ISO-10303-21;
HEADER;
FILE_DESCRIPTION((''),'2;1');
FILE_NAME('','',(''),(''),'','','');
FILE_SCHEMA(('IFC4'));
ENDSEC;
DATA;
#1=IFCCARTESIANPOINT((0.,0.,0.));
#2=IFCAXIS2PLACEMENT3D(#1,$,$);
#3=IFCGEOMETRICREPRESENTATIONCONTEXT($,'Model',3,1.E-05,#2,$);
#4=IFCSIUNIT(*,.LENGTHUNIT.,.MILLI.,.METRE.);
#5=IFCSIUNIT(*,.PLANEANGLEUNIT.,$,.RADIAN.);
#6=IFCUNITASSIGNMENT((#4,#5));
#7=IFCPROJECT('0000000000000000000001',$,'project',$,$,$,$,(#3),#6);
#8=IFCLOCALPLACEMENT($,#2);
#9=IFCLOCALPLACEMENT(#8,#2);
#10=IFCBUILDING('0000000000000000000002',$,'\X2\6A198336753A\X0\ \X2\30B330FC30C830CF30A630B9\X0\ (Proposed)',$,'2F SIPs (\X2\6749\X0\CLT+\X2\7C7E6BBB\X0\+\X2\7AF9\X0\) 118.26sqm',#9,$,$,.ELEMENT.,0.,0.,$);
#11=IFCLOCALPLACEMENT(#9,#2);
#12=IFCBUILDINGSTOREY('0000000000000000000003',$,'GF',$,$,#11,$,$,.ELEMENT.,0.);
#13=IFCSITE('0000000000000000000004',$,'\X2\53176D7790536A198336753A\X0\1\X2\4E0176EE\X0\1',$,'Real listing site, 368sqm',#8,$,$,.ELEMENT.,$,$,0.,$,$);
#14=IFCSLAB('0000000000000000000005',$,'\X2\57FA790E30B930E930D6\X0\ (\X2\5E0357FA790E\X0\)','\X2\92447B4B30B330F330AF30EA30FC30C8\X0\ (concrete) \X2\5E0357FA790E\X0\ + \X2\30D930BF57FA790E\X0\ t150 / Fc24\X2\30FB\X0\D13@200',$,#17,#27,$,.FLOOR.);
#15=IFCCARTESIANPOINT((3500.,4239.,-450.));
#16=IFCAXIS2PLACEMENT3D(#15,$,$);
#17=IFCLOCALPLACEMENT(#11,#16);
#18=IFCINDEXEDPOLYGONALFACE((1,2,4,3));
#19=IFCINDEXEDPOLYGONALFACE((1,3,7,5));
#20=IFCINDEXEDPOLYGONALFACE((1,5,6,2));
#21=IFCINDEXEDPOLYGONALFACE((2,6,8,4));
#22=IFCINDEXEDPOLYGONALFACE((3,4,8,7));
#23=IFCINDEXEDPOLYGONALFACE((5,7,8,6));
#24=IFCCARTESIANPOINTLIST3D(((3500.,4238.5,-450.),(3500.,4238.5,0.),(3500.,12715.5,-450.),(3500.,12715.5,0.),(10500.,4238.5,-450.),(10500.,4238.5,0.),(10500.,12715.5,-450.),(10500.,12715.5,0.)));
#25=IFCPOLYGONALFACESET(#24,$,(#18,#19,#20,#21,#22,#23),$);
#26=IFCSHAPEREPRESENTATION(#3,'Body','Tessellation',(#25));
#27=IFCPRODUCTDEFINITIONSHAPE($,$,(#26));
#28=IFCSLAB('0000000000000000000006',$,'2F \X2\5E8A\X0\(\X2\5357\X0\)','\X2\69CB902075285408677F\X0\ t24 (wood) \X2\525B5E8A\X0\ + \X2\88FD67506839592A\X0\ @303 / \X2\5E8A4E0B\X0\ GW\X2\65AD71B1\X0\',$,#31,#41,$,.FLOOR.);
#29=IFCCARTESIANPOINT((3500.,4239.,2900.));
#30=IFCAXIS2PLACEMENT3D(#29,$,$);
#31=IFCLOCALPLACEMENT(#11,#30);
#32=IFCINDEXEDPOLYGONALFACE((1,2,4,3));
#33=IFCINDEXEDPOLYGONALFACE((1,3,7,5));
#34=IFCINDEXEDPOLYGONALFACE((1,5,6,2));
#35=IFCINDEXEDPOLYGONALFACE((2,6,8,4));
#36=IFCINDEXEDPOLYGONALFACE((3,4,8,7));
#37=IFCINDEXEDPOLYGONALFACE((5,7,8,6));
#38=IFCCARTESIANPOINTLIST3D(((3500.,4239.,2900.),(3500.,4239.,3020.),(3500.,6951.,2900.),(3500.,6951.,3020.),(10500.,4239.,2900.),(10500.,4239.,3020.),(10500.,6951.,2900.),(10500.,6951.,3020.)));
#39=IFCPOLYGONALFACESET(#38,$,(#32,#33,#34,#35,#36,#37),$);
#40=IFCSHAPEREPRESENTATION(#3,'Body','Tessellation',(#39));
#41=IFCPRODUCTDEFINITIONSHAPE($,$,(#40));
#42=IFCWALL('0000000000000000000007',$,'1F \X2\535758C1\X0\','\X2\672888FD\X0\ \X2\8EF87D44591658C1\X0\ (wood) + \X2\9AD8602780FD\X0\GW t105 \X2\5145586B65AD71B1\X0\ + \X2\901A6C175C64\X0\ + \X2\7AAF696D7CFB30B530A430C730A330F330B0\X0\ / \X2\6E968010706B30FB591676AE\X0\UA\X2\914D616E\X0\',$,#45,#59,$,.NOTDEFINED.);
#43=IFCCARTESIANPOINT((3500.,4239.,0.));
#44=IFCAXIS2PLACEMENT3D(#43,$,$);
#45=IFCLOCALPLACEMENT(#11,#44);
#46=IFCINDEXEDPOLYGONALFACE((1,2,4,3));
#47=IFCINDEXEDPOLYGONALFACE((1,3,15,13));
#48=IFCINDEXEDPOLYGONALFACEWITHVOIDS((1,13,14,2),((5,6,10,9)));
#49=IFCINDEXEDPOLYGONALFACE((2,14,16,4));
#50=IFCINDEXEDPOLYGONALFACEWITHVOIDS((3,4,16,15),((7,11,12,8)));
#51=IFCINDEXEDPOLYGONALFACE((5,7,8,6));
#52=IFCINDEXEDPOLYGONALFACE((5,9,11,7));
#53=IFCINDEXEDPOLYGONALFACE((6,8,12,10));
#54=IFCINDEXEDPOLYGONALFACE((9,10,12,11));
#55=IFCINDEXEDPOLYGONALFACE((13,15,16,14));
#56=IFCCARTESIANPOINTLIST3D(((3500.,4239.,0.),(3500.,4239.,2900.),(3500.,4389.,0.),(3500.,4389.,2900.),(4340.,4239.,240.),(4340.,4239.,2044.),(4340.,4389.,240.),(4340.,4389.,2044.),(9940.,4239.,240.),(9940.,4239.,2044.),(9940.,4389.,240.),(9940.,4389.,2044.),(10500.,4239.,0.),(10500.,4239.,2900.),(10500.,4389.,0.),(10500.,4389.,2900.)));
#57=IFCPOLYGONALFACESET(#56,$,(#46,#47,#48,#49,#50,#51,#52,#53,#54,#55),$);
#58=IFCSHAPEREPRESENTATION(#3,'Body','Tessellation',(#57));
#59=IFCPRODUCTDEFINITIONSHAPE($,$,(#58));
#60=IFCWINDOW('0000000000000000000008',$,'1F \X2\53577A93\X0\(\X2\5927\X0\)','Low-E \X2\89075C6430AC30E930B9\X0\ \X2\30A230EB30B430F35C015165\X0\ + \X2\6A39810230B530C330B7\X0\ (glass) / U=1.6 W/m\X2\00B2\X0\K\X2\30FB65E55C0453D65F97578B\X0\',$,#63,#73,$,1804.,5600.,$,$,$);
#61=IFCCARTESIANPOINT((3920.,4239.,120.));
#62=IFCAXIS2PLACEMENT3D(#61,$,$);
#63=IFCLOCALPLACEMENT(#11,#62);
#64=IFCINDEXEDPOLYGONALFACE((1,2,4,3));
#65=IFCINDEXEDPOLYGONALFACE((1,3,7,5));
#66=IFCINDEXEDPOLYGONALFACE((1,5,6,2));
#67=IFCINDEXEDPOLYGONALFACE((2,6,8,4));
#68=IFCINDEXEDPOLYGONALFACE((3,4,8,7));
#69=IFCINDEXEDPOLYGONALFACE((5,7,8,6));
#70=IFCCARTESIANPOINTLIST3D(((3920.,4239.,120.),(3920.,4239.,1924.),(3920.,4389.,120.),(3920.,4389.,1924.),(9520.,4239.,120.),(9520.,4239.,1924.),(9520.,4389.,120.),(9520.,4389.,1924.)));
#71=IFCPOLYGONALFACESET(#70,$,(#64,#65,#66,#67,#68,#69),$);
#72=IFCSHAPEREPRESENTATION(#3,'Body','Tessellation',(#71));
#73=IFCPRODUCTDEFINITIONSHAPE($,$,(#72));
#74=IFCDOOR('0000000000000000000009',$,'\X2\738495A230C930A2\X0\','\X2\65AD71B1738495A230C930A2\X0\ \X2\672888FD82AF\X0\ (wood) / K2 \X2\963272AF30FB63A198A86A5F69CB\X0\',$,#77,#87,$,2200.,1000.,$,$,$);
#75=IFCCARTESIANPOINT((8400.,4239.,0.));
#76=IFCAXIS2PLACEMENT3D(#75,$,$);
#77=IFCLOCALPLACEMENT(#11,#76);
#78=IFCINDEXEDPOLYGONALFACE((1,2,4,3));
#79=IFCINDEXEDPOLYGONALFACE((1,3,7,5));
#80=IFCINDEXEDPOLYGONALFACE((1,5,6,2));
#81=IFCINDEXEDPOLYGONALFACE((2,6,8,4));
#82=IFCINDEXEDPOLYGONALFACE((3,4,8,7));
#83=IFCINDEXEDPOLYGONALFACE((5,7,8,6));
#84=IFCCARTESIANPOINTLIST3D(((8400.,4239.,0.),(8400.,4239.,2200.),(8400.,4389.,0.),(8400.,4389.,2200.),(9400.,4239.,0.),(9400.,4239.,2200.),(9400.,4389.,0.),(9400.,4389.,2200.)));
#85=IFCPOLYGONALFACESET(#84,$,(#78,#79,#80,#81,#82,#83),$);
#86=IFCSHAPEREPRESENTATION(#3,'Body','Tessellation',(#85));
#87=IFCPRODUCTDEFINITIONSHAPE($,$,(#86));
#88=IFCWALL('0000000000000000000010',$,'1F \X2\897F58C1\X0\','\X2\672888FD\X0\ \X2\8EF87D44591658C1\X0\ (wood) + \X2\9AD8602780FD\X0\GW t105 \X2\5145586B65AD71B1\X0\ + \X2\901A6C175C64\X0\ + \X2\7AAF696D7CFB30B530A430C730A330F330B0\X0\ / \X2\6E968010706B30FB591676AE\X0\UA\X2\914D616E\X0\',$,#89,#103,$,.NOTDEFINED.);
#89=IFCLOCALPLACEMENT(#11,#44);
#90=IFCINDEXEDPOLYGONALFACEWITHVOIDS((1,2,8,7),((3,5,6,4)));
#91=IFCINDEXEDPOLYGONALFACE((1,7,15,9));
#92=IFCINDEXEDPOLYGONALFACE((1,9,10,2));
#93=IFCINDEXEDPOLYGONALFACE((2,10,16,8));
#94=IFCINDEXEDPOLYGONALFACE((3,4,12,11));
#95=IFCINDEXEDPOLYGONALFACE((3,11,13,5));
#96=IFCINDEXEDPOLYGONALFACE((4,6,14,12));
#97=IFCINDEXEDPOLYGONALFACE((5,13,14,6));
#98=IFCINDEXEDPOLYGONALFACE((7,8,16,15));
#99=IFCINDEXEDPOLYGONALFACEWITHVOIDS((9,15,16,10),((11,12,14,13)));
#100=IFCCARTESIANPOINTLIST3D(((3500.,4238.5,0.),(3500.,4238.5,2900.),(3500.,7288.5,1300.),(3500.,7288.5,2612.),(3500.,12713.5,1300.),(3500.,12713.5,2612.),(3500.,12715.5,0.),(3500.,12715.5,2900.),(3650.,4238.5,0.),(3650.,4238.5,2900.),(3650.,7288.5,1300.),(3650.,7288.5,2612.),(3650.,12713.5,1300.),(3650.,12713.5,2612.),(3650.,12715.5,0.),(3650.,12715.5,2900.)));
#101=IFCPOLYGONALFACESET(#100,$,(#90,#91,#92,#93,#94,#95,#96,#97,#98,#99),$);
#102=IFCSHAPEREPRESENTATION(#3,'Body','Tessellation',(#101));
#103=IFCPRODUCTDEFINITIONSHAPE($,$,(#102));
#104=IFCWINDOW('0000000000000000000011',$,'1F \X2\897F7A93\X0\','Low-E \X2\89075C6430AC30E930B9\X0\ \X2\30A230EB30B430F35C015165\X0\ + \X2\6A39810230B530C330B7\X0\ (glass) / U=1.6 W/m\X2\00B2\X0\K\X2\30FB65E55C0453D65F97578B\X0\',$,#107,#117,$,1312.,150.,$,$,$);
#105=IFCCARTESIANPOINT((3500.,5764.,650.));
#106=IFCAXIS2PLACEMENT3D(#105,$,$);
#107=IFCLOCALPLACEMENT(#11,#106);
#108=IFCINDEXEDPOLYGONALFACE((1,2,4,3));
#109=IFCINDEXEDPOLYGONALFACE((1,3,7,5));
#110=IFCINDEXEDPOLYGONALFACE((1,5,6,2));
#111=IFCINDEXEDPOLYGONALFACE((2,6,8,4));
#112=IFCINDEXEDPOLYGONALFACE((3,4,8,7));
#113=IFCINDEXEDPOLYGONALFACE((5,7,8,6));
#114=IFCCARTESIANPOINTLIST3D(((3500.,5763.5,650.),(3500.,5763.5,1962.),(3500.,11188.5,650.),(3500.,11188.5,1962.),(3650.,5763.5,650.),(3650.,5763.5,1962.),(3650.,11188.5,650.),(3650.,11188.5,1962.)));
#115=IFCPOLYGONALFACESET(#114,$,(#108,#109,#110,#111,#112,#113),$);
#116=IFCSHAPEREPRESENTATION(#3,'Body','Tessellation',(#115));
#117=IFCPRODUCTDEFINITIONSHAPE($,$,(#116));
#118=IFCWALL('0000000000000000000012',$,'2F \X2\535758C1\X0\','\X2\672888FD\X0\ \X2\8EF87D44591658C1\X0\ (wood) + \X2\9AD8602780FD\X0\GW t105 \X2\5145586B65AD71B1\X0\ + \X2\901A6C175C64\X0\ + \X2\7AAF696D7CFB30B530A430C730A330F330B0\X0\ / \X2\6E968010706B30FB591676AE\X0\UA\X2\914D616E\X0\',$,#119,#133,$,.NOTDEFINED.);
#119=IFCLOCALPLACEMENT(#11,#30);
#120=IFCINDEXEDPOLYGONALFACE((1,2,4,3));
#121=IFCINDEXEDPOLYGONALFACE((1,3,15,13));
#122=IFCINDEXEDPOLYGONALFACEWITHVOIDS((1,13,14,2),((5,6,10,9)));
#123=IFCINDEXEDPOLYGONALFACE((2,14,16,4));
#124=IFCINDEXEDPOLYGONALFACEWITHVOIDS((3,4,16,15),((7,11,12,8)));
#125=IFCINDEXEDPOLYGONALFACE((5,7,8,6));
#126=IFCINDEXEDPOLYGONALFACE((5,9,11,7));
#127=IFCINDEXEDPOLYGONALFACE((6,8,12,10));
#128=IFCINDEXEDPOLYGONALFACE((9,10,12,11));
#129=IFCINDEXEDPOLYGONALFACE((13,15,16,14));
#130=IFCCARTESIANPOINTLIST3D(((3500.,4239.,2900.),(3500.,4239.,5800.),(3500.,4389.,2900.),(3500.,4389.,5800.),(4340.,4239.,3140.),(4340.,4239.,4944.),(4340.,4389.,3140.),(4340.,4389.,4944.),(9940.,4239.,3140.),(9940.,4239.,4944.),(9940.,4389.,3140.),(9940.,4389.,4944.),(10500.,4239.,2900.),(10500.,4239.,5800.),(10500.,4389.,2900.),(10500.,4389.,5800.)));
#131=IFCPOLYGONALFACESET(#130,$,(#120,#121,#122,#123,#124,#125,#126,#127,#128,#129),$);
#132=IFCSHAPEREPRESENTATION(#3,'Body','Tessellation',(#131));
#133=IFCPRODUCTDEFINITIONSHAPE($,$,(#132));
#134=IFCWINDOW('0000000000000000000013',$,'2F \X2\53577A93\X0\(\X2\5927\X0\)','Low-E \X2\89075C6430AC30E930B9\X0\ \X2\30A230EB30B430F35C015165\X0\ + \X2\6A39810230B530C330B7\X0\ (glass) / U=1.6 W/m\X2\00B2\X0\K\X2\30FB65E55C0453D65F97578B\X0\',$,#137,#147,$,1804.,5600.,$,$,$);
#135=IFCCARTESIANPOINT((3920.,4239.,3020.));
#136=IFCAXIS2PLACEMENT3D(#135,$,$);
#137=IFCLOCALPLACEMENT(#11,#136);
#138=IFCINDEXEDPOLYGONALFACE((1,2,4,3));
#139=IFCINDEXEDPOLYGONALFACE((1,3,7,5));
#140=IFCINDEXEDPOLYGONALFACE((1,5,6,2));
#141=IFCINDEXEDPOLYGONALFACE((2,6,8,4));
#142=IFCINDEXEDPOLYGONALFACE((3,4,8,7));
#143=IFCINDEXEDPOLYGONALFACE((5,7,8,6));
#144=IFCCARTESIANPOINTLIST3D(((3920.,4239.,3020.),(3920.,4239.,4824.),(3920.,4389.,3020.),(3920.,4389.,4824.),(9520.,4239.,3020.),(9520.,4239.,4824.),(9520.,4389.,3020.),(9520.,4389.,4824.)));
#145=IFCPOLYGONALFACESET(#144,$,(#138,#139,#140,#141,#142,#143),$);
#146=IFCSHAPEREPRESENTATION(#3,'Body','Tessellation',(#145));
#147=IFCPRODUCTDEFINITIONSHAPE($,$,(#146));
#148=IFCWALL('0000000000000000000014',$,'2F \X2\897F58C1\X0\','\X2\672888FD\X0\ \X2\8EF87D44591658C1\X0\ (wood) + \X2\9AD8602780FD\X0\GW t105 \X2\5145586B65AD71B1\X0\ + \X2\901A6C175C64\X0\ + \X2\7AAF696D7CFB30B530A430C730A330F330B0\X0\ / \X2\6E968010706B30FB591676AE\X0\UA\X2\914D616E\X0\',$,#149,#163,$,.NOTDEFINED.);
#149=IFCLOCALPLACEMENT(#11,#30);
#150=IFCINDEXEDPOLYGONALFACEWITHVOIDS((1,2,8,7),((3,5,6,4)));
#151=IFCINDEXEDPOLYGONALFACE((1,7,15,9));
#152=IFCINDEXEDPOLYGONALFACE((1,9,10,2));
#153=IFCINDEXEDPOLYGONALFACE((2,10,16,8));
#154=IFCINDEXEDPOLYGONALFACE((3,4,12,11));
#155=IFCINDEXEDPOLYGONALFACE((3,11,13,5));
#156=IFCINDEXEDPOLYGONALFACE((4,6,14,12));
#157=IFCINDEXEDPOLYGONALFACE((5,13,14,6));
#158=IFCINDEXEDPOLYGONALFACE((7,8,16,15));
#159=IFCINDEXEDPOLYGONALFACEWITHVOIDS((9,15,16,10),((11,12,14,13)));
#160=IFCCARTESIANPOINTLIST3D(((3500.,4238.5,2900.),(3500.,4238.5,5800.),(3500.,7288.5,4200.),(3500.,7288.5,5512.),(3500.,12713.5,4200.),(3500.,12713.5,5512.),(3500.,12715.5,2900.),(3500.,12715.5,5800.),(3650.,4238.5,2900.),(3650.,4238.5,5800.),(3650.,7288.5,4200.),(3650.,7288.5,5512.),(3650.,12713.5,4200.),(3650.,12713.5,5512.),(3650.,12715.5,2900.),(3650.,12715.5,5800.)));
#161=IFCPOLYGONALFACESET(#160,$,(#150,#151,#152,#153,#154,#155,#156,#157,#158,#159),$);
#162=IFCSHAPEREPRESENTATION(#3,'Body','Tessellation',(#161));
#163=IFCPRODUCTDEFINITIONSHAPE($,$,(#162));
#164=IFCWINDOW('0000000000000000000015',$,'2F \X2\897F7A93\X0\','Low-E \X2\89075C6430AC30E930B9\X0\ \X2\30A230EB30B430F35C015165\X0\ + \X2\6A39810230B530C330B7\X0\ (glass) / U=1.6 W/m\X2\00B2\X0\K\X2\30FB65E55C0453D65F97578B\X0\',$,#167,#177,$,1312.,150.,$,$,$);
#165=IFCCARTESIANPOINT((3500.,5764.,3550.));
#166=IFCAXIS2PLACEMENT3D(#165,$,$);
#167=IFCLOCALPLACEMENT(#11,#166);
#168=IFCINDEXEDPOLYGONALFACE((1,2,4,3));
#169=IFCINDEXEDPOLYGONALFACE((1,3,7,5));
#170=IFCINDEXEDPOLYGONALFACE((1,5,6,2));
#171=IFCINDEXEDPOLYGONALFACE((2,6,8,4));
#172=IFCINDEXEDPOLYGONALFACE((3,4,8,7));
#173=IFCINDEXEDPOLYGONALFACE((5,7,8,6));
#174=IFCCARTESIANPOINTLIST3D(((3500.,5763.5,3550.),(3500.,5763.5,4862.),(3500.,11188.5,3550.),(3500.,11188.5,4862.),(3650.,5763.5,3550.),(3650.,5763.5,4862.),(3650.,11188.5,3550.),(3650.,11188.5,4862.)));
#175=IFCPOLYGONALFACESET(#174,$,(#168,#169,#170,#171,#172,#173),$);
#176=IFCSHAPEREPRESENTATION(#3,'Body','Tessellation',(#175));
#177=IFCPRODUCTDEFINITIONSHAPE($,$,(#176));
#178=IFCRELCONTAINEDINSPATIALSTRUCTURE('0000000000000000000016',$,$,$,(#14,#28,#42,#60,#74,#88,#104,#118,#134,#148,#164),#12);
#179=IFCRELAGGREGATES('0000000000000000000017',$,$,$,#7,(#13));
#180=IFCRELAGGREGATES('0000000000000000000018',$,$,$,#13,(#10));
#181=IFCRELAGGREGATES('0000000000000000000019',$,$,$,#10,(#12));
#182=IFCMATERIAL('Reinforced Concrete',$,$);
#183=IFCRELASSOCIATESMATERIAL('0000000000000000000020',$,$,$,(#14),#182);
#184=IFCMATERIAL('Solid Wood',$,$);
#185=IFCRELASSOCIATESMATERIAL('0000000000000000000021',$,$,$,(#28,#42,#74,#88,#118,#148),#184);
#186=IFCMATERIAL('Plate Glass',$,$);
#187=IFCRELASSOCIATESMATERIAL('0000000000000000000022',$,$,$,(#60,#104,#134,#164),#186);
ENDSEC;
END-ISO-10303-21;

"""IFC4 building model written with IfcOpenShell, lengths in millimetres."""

from ifc_helpers import new_model, si_unit, frame, frame_2d, origin, place, context, project, spatial, rectangle, extrude, material, element, fill, save


model = new_model("IFC4")

# Units and contexts
model_context = context("Model", 3, precision=1e-05, world=origin())
ifc_project = project(units=[si_unit("LENGTHUNIT", "METRE", prefix="MILLI"), si_unit("PLANEANGLEUNIT", "RADIAN")], contexts=[model_context])

# Site, building, storey
site_placement = place(None, origin())
site = spatial("IfcSite", under=ifc_project, at=site_placement, Name="北海道標茶町1丁目1", ObjectType="Real listing site, 368sqm", CompositionType="ELEMENT", RefElevation=0.0)
building_placement = place(site_placement, origin())
building = spatial("IfcBuilding", under=site, at=building_placement, Name="標茶町 コートハウス (Proposed)", ObjectType="2F SIPs (杉CLT+籾殻+竹) 118.26sqm", CompositionType="ELEMENT", ElevationOfRefHeight=0.0, ElevationOfTerrain=0.0)
storey_placement = place(building_placement, origin())
storey = spatial("IfcBuildingStorey", under=building, at=storey_placement, Name="GF", CompositionType="ELEMENT", Elevation=0.0)

# Slabs
ifc_material_1 = material(Name="Reinforced Concrete")
slab_1_placement = place(storey_placement, frame((3500.0, 4239.0, -450.0)))
element("IfcSlab", 1, at=slab_1_placement, inside=storey, material=ifc_material_1, Name="基礎スラブ (布基礎)", Description="鉄筋コンクリート (concrete) 布基礎 + ベタ基礎 t150 / Fc24・D13@200", PredefinedType="FLOOR", context=model_context, shape_type="SweptSolid", body=[
    extrude(rectangle(XDim=7000.0, YDim=8477.0, at=frame_2d((3500.0, 4238.0))), frame((3500.0, 4239.0, -450.0)), (0.0, 0.0, 1.0), 450.0),
])
ifc_material_2 = material(Name="Solid Wood")
slab_2_placement = place(storey_placement, frame((3500.0, 4239.0, 2900.0)))
element("IfcSlab", 2, at=slab_2_placement, inside=storey, material=ifc_material_2, Name="2F 床(南)", Description="構造用合板 t24 (wood) 剛床 + 製材根太 @303 / 床下 GW断熱", PredefinedType="FLOOR", context=model_context, shape_type="SweptSolid", body=[
    extrude(rectangle(XDim=7000.0, YDim=2712.0, at=frame_2d((3500.0, 1356.0))), frame((3500.0, 4239.0, 2900.0)), (0.0, 0.0, 1.0), 120.0),
])

# Wall, openings, window, door
wall_1_placement = place(storey_placement, frame((3500.0, 4239.0, 0.0)))
wall_1 = element("IfcWall", 3, at=wall_1_placement, inside=storey, material=ifc_material_2, Name="1F 南壁", Description="木製 軸組外壁 (wood) + 高性能GW t105 充填断熱 + 通気層 + 窯業系サイディング / 準耐火・外皮UA配慮", PredefinedType="NOTDEFINED", context=model_context, shape_type="SweptSolid", body=[
    extrude(rectangle(XDim=7000.0, YDim=150.0, at=frame_2d((3500.0, 75.0))), frame((3500.0, 4239.0, 0.0)), (0.0, 0.0, 1.0), 2900.0),
])
opening_1_placement = place(storey_placement, frame((3920.0, 4239.0, 120.0)))
opening_1 = element("IfcOpeningElement", 4, at=opening_1_placement, cuts=wall_1, PredefinedType="NOTDEFINED", context=model_context, shape_type="SweptSolid", body=[
    extrude(rectangle(XDim=5600.0, YDim=150.0, at=frame_2d((2800.0, 75.0))), frame((3920.0, 4239.0, 120.0)), (0.0, 0.0, 1.0), 1804.0),
])
opening_2_placement = place(storey_placement, frame((8400.0, 4239.0, 0.0)))
opening_2 = element("IfcOpeningElement", 5, at=opening_2_placement, cuts=wall_1, PredefinedType="NOTDEFINED", context=model_context, shape_type="SweptSolid", body=[
    extrude(rectangle(XDim=1000.0, YDim=150.0, at=frame_2d((500.0, 75.0))), frame((8400.0, 4239.0, 0.0)), (0.0, 0.0, 1.0), 2200.0),
])
ifc_material_3 = material(Name="Plate Glass")
window_1_placement = place(storey_placement, frame((3920.0, 4239.0, 120.0)))
window_1 = element("IfcWindow", 6, at=window_1_placement, inside=storey, material=ifc_material_3, Name="1F 南窓(大)", Description="Low-E 複層ガラス アルゴン封入 + 樹脂サッシ (glass) / U=1.6 W/m²K・日射取得型", OverallHeight=1804.0, OverallWidth=5600.0, context=model_context, shape_type="SweptSolid", body=[
    extrude(rectangle(XDim=5600.0, YDim=150.0, at=frame_2d((2800.0, 75.0))), frame((3920.0, 4239.0, 120.0)), (0.0, 0.0, 1.0), 1804.0),
])
fill(opening_1, window_1)
door_placement = place(storey_placement, frame((8400.0, 4239.0, 0.0)))
door = element("IfcDoor", 7, at=door_placement, inside=storey, material=ifc_material_2, Name="玄関ドア", Description="断熱玄関ドア 木製芯 (wood) / K2 防犯・採風機構", OverallHeight=2200.0, OverallWidth=1000.0, context=model_context, shape_type="SweptSolid", body=[
    extrude(rectangle(XDim=1000.0, YDim=150.0, at=frame_2d((500.0, 75.0))), frame((8400.0, 4239.0, 0.0)), (0.0, 0.0, 1.0), 2200.0),
])
fill(opening_2, door)

# Walls, openings, windows
wall_2_placement = place(storey_placement, frame((3500.0, 4239.0, 0.0)))
wall_2 = element("IfcWall", 8, at=wall_2_placement, inside=storey, material=ifc_material_2, Name="1F 西壁", Description="木製 軸組外壁 (wood) + 高性能GW t105 充填断熱 + 通気層 + 窯業系サイディング / 準耐火・外皮UA配慮", PredefinedType="NOTDEFINED", context=model_context, shape_type="SweptSolid", body=[
    extrude(rectangle(XDim=150.0, YDim=8477.0, at=frame_2d((75.0, 4238.0))), frame((3500.0, 4239.0, 0.0)), (0.0, 0.0, 1.0), 2900.0),
])
opening_3_placement = place(storey_placement, frame((3500.0, 5764.0, 650.0)))
opening_3 = element("IfcOpeningElement", 9, at=opening_3_placement, cuts=wall_2, PredefinedType="NOTDEFINED", context=model_context, shape_type="SweptSolid", body=[
    extrude(rectangle(XDim=150.0, YDim=5425.0, at=frame_2d((75.0, 2712.0))), frame((3500.0, 5764.0, 650.0)), (0.0, 0.0, 1.0), 1312.0),
])
window_2_placement = place(storey_placement, frame((3500.0, 5764.0, 650.0)))
window_2 = element("IfcWindow", 10, at=window_2_placement, inside=storey, material=ifc_material_3, Name="1F 西窓", Description="Low-E 複層ガラス アルゴン封入 + 樹脂サッシ (glass) / U=1.6 W/m²K・日射取得型", OverallHeight=1312.0, OverallWidth=150.0, context=model_context, shape_type="SweptSolid", body=[
    extrude(rectangle(XDim=150.0, YDim=5425.0, at=frame_2d((75.0, 2712.0))), frame((3500.0, 5764.0, 650.0)), (0.0, 0.0, 1.0), 1312.0),
])
fill(opening_3, window_2)
wall_3_placement = place(storey_placement, frame((3500.0, 4239.0, 2900.0)))
wall_3 = element("IfcWall", 11, at=wall_3_placement, inside=storey, material=ifc_material_2, Name="2F 南壁", Description="木製 軸組外壁 (wood) + 高性能GW t105 充填断熱 + 通気層 + 窯業系サイディング / 準耐火・外皮UA配慮", PredefinedType="NOTDEFINED", context=model_context, shape_type="SweptSolid", body=[
    extrude(rectangle(XDim=7000.0, YDim=150.0, at=frame_2d((3500.0, 75.0))), frame((3500.0, 4239.0, 2900.0)), (0.0, 0.0, 1.0), 2900.0),
])
opening_4_placement = place(storey_placement, frame((3920.0, 4239.0, 3020.0)))
opening_4 = element("IfcOpeningElement", 12, at=opening_4_placement, cuts=wall_3, PredefinedType="NOTDEFINED", context=model_context, shape_type="SweptSolid", body=[
    extrude(rectangle(XDim=5600.0, YDim=150.0, at=frame_2d((2800.0, 75.0))), frame((3920.0, 4239.0, 3020.0)), (0.0, 0.0, 1.0), 1804.0),
])
window_3_placement = place(storey_placement, frame((3920.0, 4239.0, 3020.0)))
window_3 = element("IfcWindow", 13, at=window_3_placement, inside=storey, material=ifc_material_3, Name="2F 南窓(大)", Description="Low-E 複層ガラス アルゴン封入 + 樹脂サッシ (glass) / U=1.6 W/m²K・日射取得型", OverallHeight=1804.0, OverallWidth=5600.0, context=model_context, shape_type="SweptSolid", body=[
    extrude(rectangle(XDim=5600.0, YDim=150.0, at=frame_2d((2800.0, 75.0))), frame((3920.0, 4239.0, 3020.0)), (0.0, 0.0, 1.0), 1804.0),
])
fill(opening_4, window_3)
wall_4_placement = place(storey_placement, frame((3500.0, 4239.0, 2900.0)))
wall_4 = element("IfcWall", 14, at=wall_4_placement, inside=storey, material=ifc_material_2, Name="2F 西壁", Description="木製 軸組外壁 (wood) + 高性能GW t105 充填断熱 + 通気層 + 窯業系サイディング / 準耐火・外皮UA配慮", PredefinedType="NOTDEFINED", context=model_context, shape_type="SweptSolid", body=[
    extrude(rectangle(XDim=150.0, YDim=8477.0, at=frame_2d((75.0, 4238.0))), frame((3500.0, 4239.0, 2900.0)), (0.0, 0.0, 1.0), 2900.0),
])
opening_5_placement = place(storey_placement, frame((3500.0, 5764.0, 3550.0)))
opening_5 = element("IfcOpeningElement", 15, at=opening_5_placement, cuts=wall_4, PredefinedType="NOTDEFINED", context=model_context, shape_type="SweptSolid", body=[
    extrude(rectangle(XDim=150.0, YDim=5425.0, at=frame_2d((75.0, 2712.0))), frame((3500.0, 5764.0, 3550.0)), (0.0, 0.0, 1.0), 1312.0),
])
window_4_placement = place(storey_placement, frame((3500.0, 5764.0, 3550.0)))
window_4 = element("IfcWindow", 16, at=window_4_placement, inside=storey, material=ifc_material_3, Name="2F 西窓", Description="Low-E 複層ガラス アルゴン封入 + 樹脂サッシ (glass) / U=1.6 W/m²K・日射取得型", OverallHeight=1312.0, OverallWidth=150.0, context=model_context, shape_type="SweptSolid", body=[
    extrude(rectangle(XDim=150.0, YDim=5425.0, at=frame_2d((75.0, 2712.0))), frame((3500.0, 5764.0, 3550.0)), (0.0, 0.0, 1.0), 1312.0),
])
fill(opening_5, window_4)

save(model, "model.ifc")
